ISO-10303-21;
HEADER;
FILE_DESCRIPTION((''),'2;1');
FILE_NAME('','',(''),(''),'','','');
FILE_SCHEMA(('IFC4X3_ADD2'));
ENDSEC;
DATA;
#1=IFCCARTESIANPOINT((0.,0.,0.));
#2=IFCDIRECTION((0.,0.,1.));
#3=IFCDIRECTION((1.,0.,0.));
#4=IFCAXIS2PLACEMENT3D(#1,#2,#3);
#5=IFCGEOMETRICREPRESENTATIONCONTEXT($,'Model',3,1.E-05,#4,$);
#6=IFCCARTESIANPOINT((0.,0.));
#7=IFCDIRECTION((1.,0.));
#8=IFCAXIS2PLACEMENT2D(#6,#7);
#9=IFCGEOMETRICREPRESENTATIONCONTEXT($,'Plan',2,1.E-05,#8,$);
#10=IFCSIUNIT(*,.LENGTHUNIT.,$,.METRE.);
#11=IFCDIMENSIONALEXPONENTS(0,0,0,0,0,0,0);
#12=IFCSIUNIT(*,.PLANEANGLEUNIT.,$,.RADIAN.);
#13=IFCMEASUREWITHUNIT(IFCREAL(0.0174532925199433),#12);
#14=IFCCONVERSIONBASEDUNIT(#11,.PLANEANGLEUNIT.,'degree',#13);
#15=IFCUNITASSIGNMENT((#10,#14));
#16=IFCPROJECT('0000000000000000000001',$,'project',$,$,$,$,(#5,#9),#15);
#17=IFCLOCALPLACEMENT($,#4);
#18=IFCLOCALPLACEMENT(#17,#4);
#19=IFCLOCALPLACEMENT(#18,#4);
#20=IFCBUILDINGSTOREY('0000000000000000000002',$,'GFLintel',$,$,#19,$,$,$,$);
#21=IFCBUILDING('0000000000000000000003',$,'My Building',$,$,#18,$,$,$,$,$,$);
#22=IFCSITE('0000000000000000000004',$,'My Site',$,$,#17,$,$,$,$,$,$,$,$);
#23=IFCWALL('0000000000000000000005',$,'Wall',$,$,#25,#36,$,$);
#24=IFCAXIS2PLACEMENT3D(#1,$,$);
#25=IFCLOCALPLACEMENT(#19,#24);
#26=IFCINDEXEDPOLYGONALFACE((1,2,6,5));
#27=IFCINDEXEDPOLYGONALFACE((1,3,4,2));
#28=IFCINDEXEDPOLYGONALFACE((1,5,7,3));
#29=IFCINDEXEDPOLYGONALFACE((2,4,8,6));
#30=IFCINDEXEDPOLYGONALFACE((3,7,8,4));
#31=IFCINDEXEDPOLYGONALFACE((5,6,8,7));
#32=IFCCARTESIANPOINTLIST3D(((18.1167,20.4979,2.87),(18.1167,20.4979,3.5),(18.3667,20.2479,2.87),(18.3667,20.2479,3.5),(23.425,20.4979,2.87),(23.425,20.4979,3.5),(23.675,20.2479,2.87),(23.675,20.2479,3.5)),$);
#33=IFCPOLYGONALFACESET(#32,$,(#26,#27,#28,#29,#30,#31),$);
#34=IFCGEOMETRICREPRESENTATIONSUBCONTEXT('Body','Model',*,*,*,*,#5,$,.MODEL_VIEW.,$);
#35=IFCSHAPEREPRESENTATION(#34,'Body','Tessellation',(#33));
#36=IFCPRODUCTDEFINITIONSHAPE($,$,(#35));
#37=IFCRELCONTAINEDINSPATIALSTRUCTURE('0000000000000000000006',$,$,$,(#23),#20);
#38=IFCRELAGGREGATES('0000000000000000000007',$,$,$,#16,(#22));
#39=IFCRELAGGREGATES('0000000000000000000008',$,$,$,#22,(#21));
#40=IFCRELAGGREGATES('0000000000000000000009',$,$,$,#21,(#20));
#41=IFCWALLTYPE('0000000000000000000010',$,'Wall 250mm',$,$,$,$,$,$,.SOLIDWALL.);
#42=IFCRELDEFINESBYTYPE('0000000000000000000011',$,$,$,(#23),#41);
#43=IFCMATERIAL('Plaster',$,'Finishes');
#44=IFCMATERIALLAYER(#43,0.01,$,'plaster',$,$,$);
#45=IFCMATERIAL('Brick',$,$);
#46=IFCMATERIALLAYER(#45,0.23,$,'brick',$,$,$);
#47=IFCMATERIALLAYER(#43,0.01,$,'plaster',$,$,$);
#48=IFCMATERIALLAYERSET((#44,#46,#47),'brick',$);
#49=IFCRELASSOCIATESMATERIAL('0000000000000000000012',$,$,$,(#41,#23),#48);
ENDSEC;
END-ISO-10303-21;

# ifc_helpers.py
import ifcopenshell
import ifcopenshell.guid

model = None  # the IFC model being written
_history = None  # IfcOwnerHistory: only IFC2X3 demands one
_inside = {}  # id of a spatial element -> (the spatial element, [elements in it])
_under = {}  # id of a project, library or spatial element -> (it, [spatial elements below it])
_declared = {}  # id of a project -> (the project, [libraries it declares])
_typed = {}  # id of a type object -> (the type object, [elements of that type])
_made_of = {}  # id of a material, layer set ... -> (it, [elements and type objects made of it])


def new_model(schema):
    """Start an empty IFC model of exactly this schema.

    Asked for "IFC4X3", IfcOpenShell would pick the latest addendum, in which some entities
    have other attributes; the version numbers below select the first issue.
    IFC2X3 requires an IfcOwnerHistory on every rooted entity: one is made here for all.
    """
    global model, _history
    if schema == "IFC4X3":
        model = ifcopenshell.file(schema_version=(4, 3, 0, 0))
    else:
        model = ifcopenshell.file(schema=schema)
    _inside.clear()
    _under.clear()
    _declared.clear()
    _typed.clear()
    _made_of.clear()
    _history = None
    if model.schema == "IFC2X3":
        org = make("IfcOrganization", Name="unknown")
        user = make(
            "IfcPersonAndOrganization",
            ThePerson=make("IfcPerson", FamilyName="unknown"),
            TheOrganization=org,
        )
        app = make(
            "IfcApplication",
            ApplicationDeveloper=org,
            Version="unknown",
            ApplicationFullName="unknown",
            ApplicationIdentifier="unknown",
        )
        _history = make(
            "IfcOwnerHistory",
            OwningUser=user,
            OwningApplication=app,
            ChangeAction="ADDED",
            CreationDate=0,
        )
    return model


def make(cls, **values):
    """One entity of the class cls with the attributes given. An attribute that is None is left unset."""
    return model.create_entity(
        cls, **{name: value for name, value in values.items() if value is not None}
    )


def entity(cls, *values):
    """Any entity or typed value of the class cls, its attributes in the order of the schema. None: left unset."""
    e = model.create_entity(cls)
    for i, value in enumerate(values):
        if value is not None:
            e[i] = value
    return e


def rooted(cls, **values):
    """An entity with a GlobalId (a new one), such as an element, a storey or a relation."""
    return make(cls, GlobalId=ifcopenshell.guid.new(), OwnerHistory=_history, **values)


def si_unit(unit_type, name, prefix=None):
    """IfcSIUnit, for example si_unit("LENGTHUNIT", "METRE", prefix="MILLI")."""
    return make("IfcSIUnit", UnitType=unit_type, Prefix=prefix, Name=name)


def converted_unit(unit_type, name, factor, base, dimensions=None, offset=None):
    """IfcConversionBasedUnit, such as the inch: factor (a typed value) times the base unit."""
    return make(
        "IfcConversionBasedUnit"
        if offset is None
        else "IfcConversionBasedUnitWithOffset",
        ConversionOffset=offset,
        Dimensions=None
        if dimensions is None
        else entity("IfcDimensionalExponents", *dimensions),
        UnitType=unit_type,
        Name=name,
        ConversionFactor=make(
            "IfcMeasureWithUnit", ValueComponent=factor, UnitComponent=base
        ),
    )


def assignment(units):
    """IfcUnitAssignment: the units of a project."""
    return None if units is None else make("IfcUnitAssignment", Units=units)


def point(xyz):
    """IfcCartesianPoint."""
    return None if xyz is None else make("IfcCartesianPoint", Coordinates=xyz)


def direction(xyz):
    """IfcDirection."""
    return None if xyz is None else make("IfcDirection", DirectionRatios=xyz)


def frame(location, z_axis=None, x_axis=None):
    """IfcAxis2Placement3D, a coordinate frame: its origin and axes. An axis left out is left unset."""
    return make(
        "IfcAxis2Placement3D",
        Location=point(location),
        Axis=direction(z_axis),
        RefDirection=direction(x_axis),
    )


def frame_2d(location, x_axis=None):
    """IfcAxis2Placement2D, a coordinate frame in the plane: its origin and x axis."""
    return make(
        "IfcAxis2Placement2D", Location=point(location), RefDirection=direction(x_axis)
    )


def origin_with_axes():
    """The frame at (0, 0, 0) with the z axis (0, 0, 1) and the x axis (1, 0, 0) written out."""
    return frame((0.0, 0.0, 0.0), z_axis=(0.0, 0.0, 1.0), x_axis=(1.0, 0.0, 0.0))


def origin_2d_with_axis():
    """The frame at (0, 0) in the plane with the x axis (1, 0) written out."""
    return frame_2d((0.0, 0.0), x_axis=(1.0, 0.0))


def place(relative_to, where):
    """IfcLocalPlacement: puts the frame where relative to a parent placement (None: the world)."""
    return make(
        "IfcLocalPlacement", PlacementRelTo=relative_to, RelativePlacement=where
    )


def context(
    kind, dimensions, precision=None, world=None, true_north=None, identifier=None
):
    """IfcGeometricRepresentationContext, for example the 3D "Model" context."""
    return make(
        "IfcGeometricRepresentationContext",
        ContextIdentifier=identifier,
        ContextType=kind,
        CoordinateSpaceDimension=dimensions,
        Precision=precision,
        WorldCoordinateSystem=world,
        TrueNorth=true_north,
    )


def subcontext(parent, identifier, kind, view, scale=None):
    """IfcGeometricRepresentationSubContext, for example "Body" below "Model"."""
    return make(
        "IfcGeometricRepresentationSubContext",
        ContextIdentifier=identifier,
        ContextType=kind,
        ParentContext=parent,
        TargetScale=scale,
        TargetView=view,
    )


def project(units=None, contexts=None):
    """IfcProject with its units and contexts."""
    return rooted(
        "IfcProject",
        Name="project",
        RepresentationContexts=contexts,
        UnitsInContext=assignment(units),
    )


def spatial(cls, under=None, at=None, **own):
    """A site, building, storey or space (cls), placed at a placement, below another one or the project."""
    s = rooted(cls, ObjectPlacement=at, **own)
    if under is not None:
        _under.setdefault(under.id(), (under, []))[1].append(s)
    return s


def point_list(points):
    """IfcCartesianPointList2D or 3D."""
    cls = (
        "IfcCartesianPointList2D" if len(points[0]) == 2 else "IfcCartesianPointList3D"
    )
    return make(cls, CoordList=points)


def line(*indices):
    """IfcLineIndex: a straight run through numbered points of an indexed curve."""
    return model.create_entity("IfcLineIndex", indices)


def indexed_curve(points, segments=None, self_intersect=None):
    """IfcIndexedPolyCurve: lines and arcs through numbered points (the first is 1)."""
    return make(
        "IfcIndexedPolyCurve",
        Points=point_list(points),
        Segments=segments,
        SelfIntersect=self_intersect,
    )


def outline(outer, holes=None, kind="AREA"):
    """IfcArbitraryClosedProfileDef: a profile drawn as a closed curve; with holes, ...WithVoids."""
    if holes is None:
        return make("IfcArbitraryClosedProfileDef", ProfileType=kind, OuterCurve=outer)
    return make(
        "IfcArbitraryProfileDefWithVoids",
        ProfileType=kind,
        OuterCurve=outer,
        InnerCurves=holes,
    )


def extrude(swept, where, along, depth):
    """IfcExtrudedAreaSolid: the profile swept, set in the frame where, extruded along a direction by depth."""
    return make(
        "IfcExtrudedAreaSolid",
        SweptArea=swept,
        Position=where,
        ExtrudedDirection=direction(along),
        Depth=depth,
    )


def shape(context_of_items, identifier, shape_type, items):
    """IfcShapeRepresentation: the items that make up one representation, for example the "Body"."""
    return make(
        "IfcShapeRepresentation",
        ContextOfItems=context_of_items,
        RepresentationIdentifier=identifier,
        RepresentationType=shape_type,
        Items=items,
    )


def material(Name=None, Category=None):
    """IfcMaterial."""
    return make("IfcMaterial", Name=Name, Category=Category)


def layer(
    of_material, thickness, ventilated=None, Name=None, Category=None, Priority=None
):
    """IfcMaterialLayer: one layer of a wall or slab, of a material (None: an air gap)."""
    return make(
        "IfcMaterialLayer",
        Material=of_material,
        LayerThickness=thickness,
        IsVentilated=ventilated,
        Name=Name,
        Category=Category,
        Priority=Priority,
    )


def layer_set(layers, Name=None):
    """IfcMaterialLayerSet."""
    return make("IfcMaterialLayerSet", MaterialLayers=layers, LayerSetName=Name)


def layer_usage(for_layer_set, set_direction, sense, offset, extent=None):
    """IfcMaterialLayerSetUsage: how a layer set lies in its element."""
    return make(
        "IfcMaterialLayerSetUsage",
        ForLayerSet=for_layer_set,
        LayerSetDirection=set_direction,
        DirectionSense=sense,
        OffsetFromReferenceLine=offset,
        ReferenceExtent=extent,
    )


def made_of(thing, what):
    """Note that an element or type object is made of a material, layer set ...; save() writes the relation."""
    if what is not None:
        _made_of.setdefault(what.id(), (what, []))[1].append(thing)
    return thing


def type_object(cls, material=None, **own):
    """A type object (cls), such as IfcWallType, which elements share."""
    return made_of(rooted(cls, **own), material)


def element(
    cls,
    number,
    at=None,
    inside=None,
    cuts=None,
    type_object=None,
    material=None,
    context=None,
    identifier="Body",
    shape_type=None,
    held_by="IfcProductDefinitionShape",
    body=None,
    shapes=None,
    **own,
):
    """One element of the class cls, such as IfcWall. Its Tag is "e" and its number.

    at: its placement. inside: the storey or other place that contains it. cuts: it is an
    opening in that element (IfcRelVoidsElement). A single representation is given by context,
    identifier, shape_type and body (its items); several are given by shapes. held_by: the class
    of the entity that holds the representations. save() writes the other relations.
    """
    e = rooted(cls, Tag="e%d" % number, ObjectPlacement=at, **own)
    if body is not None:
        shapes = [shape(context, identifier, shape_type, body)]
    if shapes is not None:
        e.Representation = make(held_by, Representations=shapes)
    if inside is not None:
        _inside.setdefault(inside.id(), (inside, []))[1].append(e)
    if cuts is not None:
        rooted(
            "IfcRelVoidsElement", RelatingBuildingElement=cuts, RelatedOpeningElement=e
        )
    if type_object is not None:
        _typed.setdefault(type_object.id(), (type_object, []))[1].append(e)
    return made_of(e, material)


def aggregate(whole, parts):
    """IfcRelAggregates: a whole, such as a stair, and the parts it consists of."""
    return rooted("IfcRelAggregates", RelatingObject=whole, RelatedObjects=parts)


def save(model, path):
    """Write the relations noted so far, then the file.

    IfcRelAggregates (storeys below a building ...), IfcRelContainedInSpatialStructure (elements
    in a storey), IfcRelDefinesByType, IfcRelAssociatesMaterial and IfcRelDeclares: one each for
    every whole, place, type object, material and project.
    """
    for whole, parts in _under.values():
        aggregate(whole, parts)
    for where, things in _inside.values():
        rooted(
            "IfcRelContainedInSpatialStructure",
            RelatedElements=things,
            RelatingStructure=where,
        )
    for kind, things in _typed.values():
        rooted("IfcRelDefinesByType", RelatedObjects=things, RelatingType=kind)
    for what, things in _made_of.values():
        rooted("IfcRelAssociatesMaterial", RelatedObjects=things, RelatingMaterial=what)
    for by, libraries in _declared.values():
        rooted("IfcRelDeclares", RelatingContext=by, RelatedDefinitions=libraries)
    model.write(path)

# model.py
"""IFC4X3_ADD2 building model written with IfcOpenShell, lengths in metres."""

from ifc_helpers import new_model, entity, si_unit, converted_unit, frame, origin_with_axes, origin_2d_with_axis, place, context, subcontext, project, spatial, line, indexed_curve, outline, extrude, material, layer, layer_set, layer_usage, type_object, element, save


model = new_model("IFC4X3_ADD2")

# Units and contexts
model_context = context("Model", 3, precision=1e-05, world=origin_with_axes())
plan_context = context("Plan", 2, precision=1e-05, world=origin_2d_with_axis())
body_context = subcontext(model_context, "Body", "Model", "MODEL_VIEW")
ifc_project = project(units=[si_unit("LENGTHUNIT", "METRE"), converted_unit("PLANEANGLEUNIT", "degree", entity("IfcReal", 0.0174532925199433), si_unit("PLANEANGLEUNIT", "RADIAN"), dimensions=[0, 0, 0, 0, 0, 0, 0])], contexts=[model_context, plan_context])

# Site, building, storey
site_placement = place(None, origin_with_axes())
site = spatial("IfcSite", under=ifc_project, at=site_placement, Name="My Site")
building_placement = place(site_placement, origin_with_axes())
building = spatial("IfcBuilding", under=site, at=building_placement, Name="My Building")
storey_placement = place(building_placement, origin_with_axes())
storey = spatial("IfcBuildingStorey", under=building, at=storey_placement, Name="GFLintel")

# Shared definitions
ifc_material_1 = material(Name="Brick")

# Wall
ifc_material_2 = material(Name="Plaster", Category="Finishes")
ifc_layer_1 = layer(ifc_material_2, 0.01, Name="plaster")
ifc_layer_2 = layer(ifc_material_1, 0.23, Name="brick")
ifc_layer_3 = layer(ifc_material_2, 0.01, Name="plaster")
ifc_layer_set_1 = layer_set([ifc_layer_1, ifc_layer_2, ifc_layer_3], Name="brick")
wall_type_1 = type_object("IfcWallType", Name="Wall 250mm", PredefinedType="SOLIDWALL", material=ifc_layer_set_1)
ifc_layer_usage_1 = layer_usage(ifc_layer_set_1, "AXIS2", "POSITIVE", 0.0)
wall_1_placement = place(storey_placement, frame((18.1167, 20.2479, 2.87), z_axis=(0.0, 0.0, 1.0), x_axis=(1.0, 0.0, 0.0)))
element("IfcWall", 1, at=wall_1_placement, inside=storey, type_object=wall_type_1, material=ifc_layer_usage_1, Name="Wall", context=body_context, shape_type="SweptSolid", body=[
    extrude(outline(indexed_curve([(0.25, 0.0), (0.0, 0.25), (5.3083, 0.25), (5.5583, 0.0)], segments=[line(1, 2, 3, 4, 1)])), origin_with_axes(), (0.0, 0.0, 1.0), 0.63),
])

save(model, "model.ifc")
